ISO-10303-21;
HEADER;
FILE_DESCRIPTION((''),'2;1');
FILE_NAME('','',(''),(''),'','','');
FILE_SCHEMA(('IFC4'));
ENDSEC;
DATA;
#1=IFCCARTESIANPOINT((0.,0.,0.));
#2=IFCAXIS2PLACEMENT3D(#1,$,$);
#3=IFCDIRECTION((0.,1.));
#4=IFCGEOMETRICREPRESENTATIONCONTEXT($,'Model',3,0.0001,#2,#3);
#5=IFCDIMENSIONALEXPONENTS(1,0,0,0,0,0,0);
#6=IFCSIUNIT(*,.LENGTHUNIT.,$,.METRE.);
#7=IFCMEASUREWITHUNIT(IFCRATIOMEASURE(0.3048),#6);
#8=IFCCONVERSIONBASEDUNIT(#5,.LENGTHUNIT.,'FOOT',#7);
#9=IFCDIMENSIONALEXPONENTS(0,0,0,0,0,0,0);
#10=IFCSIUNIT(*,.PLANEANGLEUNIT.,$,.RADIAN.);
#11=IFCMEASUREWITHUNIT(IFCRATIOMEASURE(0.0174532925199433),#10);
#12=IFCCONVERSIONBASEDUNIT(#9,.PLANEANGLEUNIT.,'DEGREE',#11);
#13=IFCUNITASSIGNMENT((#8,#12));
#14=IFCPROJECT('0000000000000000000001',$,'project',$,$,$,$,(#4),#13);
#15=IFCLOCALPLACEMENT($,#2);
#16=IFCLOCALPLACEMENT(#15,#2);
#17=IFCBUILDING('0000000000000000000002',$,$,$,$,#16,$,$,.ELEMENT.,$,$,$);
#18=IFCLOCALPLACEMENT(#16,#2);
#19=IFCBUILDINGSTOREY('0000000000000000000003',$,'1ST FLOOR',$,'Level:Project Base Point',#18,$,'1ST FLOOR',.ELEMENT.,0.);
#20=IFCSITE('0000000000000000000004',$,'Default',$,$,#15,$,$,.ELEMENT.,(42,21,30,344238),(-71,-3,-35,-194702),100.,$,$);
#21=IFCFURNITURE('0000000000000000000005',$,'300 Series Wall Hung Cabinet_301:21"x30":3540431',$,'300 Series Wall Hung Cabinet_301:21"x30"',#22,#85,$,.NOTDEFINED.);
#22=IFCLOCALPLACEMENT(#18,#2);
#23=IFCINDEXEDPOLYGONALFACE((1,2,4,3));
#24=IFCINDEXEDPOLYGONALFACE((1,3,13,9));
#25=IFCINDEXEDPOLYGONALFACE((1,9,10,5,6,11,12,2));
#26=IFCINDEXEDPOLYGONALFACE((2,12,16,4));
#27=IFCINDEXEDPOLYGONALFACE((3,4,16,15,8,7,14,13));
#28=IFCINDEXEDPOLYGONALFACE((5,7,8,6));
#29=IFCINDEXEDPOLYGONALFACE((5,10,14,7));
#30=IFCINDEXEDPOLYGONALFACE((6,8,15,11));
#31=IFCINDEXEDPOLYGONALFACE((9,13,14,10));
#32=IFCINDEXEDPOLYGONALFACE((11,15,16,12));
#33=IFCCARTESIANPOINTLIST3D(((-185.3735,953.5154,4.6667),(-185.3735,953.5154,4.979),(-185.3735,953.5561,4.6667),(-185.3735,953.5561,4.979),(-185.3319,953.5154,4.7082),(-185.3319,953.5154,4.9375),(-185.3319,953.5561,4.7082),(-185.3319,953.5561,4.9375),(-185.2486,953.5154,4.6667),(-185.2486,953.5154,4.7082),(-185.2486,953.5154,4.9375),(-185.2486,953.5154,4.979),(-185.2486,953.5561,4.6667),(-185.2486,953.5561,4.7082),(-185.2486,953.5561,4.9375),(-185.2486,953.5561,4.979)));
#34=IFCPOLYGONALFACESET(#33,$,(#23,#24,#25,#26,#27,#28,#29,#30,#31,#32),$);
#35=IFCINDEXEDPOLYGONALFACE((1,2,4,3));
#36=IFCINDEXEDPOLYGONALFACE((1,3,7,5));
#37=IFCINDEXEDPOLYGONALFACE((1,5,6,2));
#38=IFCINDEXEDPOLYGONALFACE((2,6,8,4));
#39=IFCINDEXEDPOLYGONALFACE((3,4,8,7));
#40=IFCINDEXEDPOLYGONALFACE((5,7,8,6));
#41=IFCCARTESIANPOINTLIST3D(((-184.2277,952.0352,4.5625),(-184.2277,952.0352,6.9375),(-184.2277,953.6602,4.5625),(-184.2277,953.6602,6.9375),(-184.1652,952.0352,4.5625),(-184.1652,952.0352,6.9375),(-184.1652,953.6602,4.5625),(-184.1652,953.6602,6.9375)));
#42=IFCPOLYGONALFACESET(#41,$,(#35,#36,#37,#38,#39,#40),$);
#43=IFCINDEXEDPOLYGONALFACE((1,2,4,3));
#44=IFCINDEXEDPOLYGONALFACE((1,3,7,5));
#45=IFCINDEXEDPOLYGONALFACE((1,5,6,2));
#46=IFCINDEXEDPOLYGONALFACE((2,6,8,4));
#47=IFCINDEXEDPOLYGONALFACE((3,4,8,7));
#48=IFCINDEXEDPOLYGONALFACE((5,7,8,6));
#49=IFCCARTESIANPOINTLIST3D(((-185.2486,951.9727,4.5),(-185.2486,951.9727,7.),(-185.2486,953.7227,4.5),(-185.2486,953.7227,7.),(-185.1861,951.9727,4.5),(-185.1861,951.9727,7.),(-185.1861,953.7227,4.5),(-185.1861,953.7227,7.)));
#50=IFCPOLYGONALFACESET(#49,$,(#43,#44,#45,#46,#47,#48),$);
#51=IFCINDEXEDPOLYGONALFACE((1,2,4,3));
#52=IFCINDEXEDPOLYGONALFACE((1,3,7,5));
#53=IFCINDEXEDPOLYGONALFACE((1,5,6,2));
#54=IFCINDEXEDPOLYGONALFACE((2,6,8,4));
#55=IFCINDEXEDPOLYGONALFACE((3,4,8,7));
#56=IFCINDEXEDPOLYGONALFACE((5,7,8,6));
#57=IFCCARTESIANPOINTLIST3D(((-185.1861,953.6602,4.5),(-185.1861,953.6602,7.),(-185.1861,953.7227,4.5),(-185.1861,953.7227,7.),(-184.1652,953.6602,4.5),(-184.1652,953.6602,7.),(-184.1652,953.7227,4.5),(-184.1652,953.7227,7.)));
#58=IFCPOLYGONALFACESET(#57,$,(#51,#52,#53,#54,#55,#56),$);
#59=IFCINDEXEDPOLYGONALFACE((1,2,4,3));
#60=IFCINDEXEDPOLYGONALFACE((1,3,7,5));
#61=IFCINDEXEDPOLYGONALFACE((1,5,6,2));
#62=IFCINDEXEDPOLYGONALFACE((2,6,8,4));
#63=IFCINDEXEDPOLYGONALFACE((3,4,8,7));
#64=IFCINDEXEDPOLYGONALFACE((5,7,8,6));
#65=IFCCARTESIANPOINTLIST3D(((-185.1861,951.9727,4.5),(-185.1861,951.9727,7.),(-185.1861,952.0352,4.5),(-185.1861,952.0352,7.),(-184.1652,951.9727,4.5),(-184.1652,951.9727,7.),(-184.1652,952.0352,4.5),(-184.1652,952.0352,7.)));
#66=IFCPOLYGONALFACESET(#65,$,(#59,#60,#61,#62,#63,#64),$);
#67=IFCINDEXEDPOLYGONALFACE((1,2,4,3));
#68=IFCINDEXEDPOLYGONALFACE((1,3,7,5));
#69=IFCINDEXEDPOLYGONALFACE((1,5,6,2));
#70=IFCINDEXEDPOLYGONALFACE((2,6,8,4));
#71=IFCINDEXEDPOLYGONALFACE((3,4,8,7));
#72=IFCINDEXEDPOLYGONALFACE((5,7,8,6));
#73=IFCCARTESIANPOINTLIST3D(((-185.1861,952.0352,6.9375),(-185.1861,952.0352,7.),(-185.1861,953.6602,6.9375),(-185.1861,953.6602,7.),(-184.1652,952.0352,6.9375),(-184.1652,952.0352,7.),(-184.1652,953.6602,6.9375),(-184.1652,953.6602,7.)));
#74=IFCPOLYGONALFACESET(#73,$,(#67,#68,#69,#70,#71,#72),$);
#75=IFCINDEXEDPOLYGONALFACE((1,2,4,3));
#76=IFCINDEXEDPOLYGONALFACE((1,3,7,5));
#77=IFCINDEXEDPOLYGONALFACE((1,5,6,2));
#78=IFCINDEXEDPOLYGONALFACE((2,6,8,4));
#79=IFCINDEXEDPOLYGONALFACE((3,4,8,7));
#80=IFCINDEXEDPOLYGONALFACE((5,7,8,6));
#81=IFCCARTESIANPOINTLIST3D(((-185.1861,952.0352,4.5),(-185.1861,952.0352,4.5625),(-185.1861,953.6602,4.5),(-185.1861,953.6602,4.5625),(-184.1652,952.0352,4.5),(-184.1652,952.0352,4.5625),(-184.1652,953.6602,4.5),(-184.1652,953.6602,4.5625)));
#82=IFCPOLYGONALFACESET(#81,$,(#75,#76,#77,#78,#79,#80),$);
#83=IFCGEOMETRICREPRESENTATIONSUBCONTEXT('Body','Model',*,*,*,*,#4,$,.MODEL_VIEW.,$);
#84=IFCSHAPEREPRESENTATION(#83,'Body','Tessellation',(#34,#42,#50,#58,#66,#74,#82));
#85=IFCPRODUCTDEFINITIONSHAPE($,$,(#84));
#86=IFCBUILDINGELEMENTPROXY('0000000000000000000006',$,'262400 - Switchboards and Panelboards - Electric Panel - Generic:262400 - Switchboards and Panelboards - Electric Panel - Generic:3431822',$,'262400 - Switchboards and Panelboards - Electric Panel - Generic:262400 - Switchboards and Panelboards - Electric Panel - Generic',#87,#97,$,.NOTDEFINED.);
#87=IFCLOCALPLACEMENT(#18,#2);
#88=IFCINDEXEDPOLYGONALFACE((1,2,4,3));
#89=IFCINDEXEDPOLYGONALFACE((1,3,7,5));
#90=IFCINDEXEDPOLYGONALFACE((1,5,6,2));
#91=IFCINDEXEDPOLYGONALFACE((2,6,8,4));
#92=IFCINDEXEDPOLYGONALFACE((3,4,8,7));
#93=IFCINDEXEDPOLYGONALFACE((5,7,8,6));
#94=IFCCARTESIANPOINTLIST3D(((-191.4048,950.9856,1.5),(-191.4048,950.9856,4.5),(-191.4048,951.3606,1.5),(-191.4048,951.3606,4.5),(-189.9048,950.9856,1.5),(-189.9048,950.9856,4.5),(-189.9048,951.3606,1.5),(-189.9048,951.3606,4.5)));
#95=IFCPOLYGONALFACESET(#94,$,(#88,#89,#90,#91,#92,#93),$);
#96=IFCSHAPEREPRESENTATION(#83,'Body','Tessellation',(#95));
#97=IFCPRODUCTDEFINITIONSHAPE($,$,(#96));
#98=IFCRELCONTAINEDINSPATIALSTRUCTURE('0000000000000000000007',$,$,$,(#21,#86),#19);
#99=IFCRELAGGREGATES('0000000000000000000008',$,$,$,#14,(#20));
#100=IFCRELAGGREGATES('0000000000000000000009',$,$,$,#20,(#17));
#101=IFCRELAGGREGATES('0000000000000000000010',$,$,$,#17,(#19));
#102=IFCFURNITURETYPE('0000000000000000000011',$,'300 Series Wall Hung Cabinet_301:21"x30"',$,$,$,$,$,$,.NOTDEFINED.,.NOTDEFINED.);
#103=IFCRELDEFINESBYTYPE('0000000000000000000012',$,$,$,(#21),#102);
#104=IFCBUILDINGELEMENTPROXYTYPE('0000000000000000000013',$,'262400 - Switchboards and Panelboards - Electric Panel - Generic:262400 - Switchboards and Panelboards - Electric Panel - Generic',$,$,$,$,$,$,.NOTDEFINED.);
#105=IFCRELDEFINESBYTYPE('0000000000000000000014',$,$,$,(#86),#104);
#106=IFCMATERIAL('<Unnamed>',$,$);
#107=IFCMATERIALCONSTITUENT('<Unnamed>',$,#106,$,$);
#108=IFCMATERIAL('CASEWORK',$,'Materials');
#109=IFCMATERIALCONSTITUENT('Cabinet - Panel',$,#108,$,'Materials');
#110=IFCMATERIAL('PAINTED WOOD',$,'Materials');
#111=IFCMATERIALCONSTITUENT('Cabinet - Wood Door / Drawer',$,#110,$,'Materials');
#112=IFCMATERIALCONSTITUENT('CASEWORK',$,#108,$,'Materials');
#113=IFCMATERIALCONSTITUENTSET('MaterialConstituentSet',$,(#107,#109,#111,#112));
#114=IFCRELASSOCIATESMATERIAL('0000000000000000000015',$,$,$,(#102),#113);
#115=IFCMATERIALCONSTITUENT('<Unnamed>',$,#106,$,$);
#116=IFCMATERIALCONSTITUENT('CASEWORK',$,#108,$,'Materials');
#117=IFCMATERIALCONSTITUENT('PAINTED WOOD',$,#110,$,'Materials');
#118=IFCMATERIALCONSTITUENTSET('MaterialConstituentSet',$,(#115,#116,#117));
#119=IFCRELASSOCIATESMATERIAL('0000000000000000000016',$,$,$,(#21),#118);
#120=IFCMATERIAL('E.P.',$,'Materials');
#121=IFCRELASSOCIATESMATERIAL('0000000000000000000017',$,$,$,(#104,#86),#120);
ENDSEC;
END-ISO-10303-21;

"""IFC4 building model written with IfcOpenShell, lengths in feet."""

from ifc_helpers import new_model, entity, si_unit, converted_unit, direction, frame, frame_2d, origin, origin_2d_with_axis, place, context, subcontext, project, spatial, polyline, rectangle, outline, extrude, source, transform, mapped, material, constituent, constituent_set, type_object, type_shapes, element, save


model = new_model("IFC4")

# Units and contexts
model_context = context("Model", 3, precision=0.0001, world=origin(), true_north=direction((0.0, 1.0)))
body_context = subcontext(model_context, "Body", "Model", "MODEL_VIEW")
ifc_project = project(units=[converted_unit("LENGTHUNIT", "FOOT", entity("IfcRatioMeasure", 0.3048), si_unit("LENGTHUNIT", "METRE"), dimensions=[1, 0, 0, 0, 0, 0, 0]), converted_unit("PLANEANGLEUNIT", "DEGREE", entity("IfcRatioMeasure", 0.0174532925199433), si_unit("PLANEANGLEUNIT", "RADIAN"), dimensions=[0, 0, 0, 0, 0, 0, 0])], contexts=[model_context])

# Site, building, storey
site_placement = place(None, origin())
site = spatial("IfcSite", under=ifc_project, at=site_placement, Name="Default", CompositionType="ELEMENT", RefLatitude=(42, 21, 30, 344238), RefLongitude=(-71, -3, -35, -194702), RefElevation=100.0)
building_placement = place(site_placement, origin())
building = spatial("IfcBuilding", under=site, at=building_placement, CompositionType="ELEMENT")
storey_placement = place(building_placement, origin())
storey = spatial("IfcBuildingStorey", under=building, at=storey_placement, Name="1ST FLOOR", ObjectType="Level:Project Base Point", LongName="1ST FLOOR", CompositionType="ELEMENT", Elevation=0.0)

# Shared definitions
ifc_material_1 = material(Name="<Unnamed>")

# Shared definitions
ifc_material_2 = material(Name="PAINTED WOOD", Category="Materials")
ifc_material_3 = material(Name="CASEWORK", Category="Materials")

# Furniture
ifc_constituent_1 = constituent(ifc_material_1, Name="<Unnamed>")
ifc_constituent_2 = constituent(ifc_material_3, Name="CASEWORK", Category="Materials")
ifc_constituent_3 = constituent(ifc_material_2, Name="PAINTED WOOD", Category="Materials")
ifc_constituent_set_1 = constituent_set(constituents=[ifc_constituent_1, ifc_constituent_2, ifc_constituent_3], Name="MaterialConstituentSet")
ifc_constituent_4 = constituent(ifc_material_1, Name="<Unnamed>")
ifc_constituent_5 = constituent(ifc_material_3, Name="Cabinet - Panel", Category="Materials")
ifc_constituent_6 = constituent(ifc_material_2, Name="Cabinet - Wood Door / Drawer", Category="Materials")
ifc_constituent_7 = constituent(ifc_material_3, Name="CASEWORK", Category="Materials")
ifc_constituent_set_2 = constituent_set(constituents=[ifc_constituent_4, ifc_constituent_5, ifc_constituent_6, ifc_constituent_7], Name="MaterialConstituentSet")
furniture_type_1 = type_object("IfcFurnitureType", Name="300 Series Wall Hung Cabinet_301:21\"x30\"", AssemblyPlace="NOTDEFINED", PredefinedType="NOTDEFINED", material=ifc_constituent_set_2)
shared_shape_1 = source(origin(), body_context, "Body", "SweptSolid", [
    extrude(outline(polyline([(0.1146, -0.0521), (0.1562, -0.0521), (0.1562, 0.0729), (-0.1562, 0.0729), (-0.1562, -0.0521), (-0.1146, -0.0521), (-0.1146, 0.0313), (0.1146, 0.0313), (0.1146, -0.0521)])), frame((0.1667, 0.0729, 0.3229), z_axis=(1.0, 0.0, 0.0), x_axis=(0.0, 0.0, 1.0)), (0.0, 0.0, 1.0), 0.0407),
    extrude(rectangle(XDim=1.625, YDim=0.0625, at=origin_2d_with_axis()), frame((0.875, 1.177, 0.0625), z_axis=(0.0, 0.0, 1.0), x_axis=(-1.0, 0.0, 0.0)), (0.0, 0.0, 1.0), 2.375),
    extrude(rectangle(XDim=1.75, YDim=0.0625, at=origin_2d_with_axis()), frame((0.875, 0.1562, 0.0), z_axis=(0.0, 0.0, 1.0), x_axis=(-1.0, 0.0, 0.0)), (0.0, 0.0, 1.0), 2.5),
    extrude(rectangle(XDim=1.0208, YDim=0.0625, at=frame_2d((0.0, 0.0), x_axis=(1.0, 0.0))), frame((0.0313, 0.6979, 0.0), z_axis=(0.0, 0.0, 1.0), x_axis=(0.0, -1.0, 0.0)), (0.0, 0.0, 1.0), 2.5),
    extrude(rectangle(XDim=1.0208, YDim=0.0625, at=frame_2d((0.0, 0.0), x_axis=(1.0, 0.0))), frame((1.7188, 0.6979, 0.0), z_axis=(0.0, 0.0, 1.0), x_axis=(0.0, -1.0, 0.0)), (0.0, 0.0, 1.0), 2.5),
    extrude(rectangle(XDim=1.0208, YDim=1.625, at=origin_2d_with_axis()), frame((0.875, 0.6979, 2.4375), z_axis=(0.0, 0.0, 1.0), x_axis=(0.0, 1.0, 0.0)), (0.0, 0.0, 1.0), 0.0625),
    extrude(rectangle(XDim=1.0208, YDim=1.625, at=origin_2d_with_axis()), frame((0.875, 0.6979, 0.0), z_axis=(0.0, 0.0, 1.0), x_axis=(0.0, 1.0, 0.0)), (0.0, 0.0, 1.0), 0.0625),
])
type_shapes(furniture_type_1, [shared_shape_1])
furniture_1_placement = place(storey_placement, frame((-185.3735, 953.7227, 4.5), z_axis=(0.0, 0.0, 1.0), x_axis=(0.0, -1.0, 0.0)))
element("IfcFurniture", 1, at=furniture_1_placement, inside=storey, type_object=furniture_type_1, material=ifc_constituent_set_1, Name="300 Series Wall Hung Cabinet_301:21\"x30\":3540431", ObjectType="300 Series Wall Hung Cabinet_301:21\"x30\"", PredefinedType="NOTDEFINED", context=body_context, shape_type="MappedRepresentation", body=[
    mapped(shared_shape_1, transform((0.0, 0.0, 0.0), scale=1.0)),
])

# Building element proxy
ifc_material_4 = material(Name="E.P.", Category="Materials")
building_element_proxy_type_1 = type_object("IfcBuildingElementProxyType", Name="262400 - Switchboards and Panelboards - Electric Panel - Generic:262400 - Switchboards and Panelboards - Electric Panel - Generic", PredefinedType="NOTDEFINED", material=ifc_material_4)
shared_shape_2 = source(origin(), body_context, "Body", "SweptSolid", [
    extrude(rectangle(XDim=0.375, YDim=1.5, at=origin_2d_with_axis()), frame((0.75, 0.1875, 0.0), z_axis=(0.0, 0.0, 1.0), x_axis=(0.0, 1.0, 0.0)), (0.0, 0.0, 1.0), 3.0),
])
type_shapes(building_element_proxy_type_1, [shared_shape_2])
proxy_1_placement = place(storey_placement, frame((-191.4048, 950.9856, 1.5)))
element("IfcBuildingElementProxy", 2, at=proxy_1_placement, inside=storey, type_object=building_element_proxy_type_1, material=ifc_material_4, Name="262400 - Switchboards and Panelboards - Electric Panel - Generic:262400 - Switchboards and Panelboards - Electric Panel - Generic:3431822", ObjectType="262400 - Switchboards and Panelboards - Electric Panel - Generic:262400 - Switchboards and Panelboards - Electric Panel - Generic", PredefinedType="NOTDEFINED", context=body_context, shape_type="MappedRepresentation", body=[
    mapped(shared_shape_2, transform((0.0, 0.0, 0.0), scale=1.0)),
])

save(model, "model.ifc")
